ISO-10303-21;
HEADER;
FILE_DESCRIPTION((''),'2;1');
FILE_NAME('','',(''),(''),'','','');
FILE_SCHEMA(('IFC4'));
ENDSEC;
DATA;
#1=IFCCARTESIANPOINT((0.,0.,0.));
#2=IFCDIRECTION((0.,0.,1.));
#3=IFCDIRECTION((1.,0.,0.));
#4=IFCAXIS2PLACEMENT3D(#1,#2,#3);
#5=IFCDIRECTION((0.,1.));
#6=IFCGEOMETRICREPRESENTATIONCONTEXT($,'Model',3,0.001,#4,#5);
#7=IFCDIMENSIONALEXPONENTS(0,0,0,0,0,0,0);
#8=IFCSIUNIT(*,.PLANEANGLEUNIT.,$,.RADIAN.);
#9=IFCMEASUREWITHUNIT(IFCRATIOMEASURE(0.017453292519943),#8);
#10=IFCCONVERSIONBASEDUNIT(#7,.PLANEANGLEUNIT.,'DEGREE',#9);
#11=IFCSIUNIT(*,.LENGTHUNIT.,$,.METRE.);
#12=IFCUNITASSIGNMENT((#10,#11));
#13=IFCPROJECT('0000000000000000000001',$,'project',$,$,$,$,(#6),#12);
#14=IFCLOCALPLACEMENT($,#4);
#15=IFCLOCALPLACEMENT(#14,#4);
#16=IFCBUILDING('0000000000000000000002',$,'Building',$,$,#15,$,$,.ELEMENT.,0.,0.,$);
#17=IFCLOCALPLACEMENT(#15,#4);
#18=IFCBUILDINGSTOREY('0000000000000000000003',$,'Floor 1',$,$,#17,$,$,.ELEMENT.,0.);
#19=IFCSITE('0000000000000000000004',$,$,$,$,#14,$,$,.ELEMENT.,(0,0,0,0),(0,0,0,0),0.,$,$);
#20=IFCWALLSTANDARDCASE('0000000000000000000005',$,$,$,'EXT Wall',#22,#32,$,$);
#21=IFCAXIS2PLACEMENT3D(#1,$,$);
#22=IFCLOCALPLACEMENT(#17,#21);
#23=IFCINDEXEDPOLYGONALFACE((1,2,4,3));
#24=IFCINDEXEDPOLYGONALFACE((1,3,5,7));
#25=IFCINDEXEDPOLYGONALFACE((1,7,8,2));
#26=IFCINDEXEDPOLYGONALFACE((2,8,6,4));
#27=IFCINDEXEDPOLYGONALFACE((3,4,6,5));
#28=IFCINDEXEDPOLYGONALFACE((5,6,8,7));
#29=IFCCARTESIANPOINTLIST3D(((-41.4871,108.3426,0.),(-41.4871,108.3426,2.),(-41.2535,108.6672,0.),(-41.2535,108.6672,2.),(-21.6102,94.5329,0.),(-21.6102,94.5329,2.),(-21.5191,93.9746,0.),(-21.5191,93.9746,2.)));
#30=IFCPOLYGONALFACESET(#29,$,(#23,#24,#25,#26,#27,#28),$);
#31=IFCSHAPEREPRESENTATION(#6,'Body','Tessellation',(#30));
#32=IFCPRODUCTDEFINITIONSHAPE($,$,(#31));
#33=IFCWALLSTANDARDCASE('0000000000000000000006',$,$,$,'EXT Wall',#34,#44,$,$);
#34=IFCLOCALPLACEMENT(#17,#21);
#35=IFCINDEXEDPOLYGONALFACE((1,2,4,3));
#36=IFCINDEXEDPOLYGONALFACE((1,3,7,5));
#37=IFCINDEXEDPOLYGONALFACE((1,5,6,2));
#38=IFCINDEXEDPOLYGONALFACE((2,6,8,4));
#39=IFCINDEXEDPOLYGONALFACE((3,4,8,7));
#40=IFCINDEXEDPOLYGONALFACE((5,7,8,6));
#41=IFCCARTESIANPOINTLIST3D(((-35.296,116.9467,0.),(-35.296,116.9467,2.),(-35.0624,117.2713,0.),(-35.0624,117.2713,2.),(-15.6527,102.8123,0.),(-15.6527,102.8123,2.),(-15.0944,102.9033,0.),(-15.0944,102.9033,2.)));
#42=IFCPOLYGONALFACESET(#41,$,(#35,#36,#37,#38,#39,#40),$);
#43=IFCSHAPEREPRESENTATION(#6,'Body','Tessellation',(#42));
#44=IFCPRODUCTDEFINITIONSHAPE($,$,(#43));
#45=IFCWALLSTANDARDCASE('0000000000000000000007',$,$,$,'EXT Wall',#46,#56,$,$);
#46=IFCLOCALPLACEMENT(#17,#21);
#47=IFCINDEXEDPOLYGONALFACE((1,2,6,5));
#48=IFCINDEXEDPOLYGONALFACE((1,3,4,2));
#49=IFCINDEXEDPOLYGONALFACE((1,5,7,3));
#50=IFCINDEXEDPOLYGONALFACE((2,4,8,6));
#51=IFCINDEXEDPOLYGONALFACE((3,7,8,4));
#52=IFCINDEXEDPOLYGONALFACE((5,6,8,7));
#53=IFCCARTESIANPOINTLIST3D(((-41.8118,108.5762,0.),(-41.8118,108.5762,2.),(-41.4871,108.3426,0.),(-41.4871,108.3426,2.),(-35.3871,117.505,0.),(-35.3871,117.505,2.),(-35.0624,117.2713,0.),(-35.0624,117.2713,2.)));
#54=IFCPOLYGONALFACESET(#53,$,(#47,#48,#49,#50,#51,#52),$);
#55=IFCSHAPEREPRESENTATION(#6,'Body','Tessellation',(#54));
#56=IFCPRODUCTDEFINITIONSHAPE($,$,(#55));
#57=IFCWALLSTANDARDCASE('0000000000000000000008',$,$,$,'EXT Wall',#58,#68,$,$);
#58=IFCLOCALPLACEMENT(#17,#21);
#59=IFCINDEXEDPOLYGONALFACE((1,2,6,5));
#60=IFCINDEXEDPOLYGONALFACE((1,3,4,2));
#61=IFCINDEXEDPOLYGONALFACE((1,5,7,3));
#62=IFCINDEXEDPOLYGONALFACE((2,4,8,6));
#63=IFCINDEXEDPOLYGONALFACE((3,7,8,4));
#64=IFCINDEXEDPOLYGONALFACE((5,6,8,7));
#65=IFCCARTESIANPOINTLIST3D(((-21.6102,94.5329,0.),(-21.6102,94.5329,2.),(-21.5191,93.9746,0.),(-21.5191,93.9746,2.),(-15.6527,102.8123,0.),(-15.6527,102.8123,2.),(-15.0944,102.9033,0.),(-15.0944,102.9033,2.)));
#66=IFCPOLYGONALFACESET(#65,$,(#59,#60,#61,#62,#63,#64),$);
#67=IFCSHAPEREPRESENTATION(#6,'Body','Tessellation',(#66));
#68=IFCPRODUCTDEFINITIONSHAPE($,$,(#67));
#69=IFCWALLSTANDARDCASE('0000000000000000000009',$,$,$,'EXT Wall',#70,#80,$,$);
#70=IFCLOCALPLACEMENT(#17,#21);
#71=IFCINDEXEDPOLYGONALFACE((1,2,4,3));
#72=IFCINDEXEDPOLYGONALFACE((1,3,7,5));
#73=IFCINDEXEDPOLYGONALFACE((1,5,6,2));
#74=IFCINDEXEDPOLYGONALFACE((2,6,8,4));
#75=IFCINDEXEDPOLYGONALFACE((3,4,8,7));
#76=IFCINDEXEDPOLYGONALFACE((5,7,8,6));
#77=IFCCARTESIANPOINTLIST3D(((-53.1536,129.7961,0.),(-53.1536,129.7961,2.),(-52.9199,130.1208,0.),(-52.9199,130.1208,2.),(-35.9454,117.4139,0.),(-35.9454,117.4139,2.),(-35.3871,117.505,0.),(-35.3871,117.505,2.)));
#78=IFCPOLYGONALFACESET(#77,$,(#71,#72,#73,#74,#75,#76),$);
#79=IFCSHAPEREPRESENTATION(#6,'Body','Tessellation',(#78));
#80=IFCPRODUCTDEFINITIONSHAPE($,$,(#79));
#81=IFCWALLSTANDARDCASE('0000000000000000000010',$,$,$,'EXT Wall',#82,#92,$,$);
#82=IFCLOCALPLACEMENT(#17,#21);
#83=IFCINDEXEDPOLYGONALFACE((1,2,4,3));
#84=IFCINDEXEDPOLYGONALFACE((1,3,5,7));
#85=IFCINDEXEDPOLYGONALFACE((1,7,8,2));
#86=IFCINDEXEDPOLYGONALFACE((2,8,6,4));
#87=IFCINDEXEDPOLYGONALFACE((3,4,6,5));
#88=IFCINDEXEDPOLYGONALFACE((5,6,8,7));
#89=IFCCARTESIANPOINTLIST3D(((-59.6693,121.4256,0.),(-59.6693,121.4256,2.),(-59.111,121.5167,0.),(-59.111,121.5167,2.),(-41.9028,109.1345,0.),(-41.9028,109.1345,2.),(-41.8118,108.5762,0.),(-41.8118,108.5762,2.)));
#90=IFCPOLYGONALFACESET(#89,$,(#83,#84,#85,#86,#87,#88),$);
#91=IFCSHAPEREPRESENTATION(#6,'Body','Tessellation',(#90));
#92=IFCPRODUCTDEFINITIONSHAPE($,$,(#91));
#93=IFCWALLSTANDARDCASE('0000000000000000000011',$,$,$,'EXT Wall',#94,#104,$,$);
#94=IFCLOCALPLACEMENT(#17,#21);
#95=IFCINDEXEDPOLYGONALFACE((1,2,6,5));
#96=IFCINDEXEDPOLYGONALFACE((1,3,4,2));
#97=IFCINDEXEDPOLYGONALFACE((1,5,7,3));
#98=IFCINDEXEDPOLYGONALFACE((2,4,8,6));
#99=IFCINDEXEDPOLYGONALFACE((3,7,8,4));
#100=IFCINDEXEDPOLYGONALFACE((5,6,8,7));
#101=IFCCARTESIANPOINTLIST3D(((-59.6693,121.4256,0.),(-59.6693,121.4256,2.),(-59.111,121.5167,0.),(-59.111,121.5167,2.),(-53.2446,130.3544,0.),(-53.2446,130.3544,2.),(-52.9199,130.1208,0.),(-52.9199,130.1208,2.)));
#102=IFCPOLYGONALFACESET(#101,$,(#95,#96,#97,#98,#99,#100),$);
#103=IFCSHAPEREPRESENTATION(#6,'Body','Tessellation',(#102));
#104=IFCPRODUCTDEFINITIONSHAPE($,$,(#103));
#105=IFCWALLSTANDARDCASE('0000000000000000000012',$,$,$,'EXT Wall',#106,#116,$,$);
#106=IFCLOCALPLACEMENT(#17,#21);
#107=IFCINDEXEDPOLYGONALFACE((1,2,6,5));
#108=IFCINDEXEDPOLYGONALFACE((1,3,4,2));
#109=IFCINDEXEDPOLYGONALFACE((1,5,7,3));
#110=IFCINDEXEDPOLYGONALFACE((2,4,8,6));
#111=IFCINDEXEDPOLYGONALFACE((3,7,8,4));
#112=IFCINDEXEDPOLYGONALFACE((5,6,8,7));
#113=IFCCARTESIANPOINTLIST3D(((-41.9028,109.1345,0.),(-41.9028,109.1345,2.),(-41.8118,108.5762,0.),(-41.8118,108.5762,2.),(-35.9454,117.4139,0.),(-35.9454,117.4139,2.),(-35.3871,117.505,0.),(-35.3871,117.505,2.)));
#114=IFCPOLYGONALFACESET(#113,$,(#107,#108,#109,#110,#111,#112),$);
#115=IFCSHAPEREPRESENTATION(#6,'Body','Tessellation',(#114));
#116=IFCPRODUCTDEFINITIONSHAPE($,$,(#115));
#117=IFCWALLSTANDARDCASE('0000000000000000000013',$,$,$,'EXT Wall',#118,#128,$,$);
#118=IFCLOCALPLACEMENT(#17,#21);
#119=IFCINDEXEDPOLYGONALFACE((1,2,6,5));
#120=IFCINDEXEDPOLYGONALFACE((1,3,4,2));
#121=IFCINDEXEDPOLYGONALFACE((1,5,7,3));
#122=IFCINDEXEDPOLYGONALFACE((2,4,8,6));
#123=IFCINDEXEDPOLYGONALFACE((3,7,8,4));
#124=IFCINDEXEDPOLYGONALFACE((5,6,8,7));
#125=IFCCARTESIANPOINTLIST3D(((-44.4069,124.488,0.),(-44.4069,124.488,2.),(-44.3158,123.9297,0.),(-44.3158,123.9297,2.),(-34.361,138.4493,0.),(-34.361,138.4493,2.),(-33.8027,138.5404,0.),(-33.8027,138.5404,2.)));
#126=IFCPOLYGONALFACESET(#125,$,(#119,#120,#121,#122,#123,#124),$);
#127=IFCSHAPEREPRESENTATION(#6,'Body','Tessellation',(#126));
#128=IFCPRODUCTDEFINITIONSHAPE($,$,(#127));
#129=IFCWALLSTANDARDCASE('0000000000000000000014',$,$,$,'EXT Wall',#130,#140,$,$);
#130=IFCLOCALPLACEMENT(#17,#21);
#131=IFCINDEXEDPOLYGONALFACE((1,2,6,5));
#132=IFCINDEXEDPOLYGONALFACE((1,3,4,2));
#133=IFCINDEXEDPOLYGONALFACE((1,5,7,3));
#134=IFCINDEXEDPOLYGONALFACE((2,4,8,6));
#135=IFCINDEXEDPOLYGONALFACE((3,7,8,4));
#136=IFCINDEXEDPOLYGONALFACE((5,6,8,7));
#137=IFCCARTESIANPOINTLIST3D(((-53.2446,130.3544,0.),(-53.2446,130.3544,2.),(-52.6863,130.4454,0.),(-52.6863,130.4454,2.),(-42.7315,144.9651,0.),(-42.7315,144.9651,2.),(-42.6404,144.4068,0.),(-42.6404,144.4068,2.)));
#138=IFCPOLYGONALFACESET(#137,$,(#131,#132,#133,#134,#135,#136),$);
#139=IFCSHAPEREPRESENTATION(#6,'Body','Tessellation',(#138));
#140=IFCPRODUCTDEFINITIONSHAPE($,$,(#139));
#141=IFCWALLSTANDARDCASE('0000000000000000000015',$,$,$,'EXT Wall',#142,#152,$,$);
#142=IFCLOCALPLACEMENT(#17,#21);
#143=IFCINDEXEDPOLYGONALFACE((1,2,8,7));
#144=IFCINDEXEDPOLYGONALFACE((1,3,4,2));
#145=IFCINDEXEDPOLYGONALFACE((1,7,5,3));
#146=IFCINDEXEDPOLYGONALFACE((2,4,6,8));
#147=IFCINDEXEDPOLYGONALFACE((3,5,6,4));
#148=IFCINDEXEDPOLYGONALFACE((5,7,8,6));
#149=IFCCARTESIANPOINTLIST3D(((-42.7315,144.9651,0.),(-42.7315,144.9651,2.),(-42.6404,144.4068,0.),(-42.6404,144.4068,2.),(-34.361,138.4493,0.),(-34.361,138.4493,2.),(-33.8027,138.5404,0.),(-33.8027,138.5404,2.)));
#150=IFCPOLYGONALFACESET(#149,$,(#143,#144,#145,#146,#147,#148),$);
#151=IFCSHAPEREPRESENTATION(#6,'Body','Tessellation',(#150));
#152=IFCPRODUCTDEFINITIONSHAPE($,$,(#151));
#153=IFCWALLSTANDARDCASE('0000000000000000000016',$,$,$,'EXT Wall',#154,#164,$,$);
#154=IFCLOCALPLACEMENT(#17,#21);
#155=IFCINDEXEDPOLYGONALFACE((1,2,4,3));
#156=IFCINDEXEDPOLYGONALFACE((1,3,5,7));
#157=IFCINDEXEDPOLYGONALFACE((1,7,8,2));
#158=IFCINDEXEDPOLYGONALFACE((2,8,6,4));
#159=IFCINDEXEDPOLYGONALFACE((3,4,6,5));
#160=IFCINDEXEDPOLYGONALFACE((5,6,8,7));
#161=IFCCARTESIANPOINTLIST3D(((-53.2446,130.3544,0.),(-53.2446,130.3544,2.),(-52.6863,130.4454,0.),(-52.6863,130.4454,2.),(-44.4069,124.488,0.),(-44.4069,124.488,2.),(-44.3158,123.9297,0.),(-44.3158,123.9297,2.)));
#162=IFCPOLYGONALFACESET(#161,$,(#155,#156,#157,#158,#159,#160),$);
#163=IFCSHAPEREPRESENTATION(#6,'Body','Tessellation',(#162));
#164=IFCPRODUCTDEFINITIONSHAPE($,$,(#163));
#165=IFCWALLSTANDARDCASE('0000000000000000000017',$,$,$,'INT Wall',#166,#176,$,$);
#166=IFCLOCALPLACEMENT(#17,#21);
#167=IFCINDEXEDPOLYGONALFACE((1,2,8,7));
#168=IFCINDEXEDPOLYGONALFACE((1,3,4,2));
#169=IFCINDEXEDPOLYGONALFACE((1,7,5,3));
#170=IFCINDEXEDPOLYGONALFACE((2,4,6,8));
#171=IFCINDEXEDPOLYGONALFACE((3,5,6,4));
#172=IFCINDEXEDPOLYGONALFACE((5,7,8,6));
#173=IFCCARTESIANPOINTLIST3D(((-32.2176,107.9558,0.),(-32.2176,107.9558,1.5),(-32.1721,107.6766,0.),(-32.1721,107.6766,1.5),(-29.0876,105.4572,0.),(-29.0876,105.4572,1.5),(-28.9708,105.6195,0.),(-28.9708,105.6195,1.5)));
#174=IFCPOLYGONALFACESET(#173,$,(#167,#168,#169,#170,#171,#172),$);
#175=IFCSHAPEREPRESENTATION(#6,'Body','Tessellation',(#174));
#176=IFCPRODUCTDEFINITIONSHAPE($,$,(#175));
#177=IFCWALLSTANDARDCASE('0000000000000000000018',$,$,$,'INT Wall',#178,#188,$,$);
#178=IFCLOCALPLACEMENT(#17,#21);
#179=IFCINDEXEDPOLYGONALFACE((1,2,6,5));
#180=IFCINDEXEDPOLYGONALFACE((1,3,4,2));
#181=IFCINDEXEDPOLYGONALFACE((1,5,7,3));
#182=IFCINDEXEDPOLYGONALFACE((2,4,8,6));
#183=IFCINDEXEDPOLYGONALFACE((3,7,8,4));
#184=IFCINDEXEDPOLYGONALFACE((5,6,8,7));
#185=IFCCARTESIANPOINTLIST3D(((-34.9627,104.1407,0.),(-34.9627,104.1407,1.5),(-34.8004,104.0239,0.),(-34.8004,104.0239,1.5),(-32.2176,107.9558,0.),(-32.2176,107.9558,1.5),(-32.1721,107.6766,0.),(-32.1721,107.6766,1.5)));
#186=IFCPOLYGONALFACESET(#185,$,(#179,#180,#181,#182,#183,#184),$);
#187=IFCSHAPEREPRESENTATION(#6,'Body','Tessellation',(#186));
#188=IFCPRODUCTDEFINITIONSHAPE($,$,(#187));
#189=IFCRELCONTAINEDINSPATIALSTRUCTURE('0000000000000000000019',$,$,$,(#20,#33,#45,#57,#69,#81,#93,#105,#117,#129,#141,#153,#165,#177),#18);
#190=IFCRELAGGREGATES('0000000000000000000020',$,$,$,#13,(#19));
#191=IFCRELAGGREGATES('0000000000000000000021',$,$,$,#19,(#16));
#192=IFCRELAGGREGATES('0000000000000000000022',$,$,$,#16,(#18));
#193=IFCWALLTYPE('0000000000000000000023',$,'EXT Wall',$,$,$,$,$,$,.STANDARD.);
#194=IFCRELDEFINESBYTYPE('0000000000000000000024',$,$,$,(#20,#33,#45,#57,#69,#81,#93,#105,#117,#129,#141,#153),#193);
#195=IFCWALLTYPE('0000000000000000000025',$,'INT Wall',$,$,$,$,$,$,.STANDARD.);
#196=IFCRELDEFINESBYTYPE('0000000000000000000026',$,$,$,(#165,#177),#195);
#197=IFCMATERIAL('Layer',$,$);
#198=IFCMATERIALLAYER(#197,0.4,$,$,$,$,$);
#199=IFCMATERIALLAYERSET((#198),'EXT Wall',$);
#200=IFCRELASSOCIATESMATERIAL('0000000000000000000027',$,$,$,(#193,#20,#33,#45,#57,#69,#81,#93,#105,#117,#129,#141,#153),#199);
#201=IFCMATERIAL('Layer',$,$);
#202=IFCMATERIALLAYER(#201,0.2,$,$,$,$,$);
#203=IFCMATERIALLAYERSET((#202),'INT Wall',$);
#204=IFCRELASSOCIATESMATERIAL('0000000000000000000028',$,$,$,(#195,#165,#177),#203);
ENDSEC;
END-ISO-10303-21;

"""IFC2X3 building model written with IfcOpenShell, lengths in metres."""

from ifc_helpers import new_model, entity, si_unit, converted_unit, direction, frame, origin_with_axes, place, context, project, spatial, polyline, outline, extrude, material, layer, layer_set, layer_usage, type_object, element, save


model = new_model("IFC2X3")

# Units and contexts
model_context = context("Model", 3, precision=0.001, world=origin_with_axes(), true_north=direction((0.0, 1.0)))
ifc_project = project(units=[converted_unit("PLANEANGLEUNIT", "DEGREE", entity("IfcRatioMeasure", 0.017453292519943), si_unit("PLANEANGLEUNIT", "RADIAN"), dimensions=[0, 0, 0, 0, 0, 0, 0]), si_unit("LENGTHUNIT", "METRE")], contexts=[model_context])

# Site, building, storey
site_placement = place(None, origin_with_axes())
site = spatial("IfcSite", under=ifc_project, at=site_placement, CompositionType="ELEMENT", RefLatitude=(0, 0, 0, 0), RefLongitude=(0, 0, 0, 0), RefElevation=0.0)
building_placement = place(site_placement, origin_with_axes())
building = spatial("IfcBuilding", under=site, at=building_placement, Name="Building", CompositionType="ELEMENT", ElevationOfRefHeight=0.0, ElevationOfTerrain=0.0)
storey_placement = place(building_placement, origin_with_axes())
storey = spatial("IfcBuildingStorey", under=building, at=storey_placement, Name="Floor 1", CompositionType="ELEMENT", Elevation=0.0)

# Walls
ifc_material_1 = material(Name="Layer")
ifc_layer_1 = layer(ifc_material_1, 0.4)
ifc_layer_set_1 = layer_set([ifc_layer_1], Name="EXT Wall")
ifc_layer_usage_1 = layer_usage(ifc_layer_set_1, "AXIS2", "POSITIVE", -0.2)
wall_type_1 = type_object("IfcWallType", Name="EXT Wall", PredefinedType="STANDARD", material=ifc_layer_set_1)
wall_1_placement = place(site_placement, frame((-41.8118, 108.5762, 0.0), z_axis=(0.0, 0.0, 1.0), x_axis=(0.811707, -0.584065, 0.0)))
element("IfcWallStandardCase", 1, at=wall_1_placement, inside=storey, type_object=wall_type_1, material=ifc_layer_usage_1, ObjectType="EXT Wall", context=model_context, shape_type="SweptSolid", body=[
    extrude(outline(polyline([(0.4, 0.0), (0.4, 0.4), (24.6, 0.4), (25.0, 0.0), (0.4, 0.0)])), origin_with_axes(), (0.0, 0.0, 1.0), 2.0),
])
wall_2_placement = place(site_placement, frame((-15.0944, 102.9033, 0.0), z_axis=(0.0, 0.0, 1.0), x_axis=(-0.811707, 0.584065, 0.0)))
element("IfcWallStandardCase", 2, at=wall_2_placement, inside=storey, type_object=wall_type_1, material=ifc_layer_usage_1, ObjectType="EXT Wall", context=model_context, shape_type="SweptSolid", body=[
    extrude(outline(polyline([(24.6, 0.4), (24.6, 0.0), (0.0, 0.0), (0.4, 0.4), (24.6, 0.4)])), origin_with_axes(), (0.0, 0.0, 1.0), 2.0),
])
wall_3_placement = place(site_placement, frame((-35.3871, 117.505, 0.0), z_axis=(0.0, 0.0, 1.0), x_axis=(-0.584065, -0.811707, 0.0)))
element("IfcWallStandardCase", 3, at=wall_3_placement, inside=storey, type_object=wall_type_1, material=ifc_layer_usage_1, ObjectType="EXT Wall", context=model_context, shape_type="SweptSolid", body=[
    extrude(outline(polyline([(11.0, 0.0), (11.0, 0.4), (0.0, 0.4), (0.0, 0.0), (11.0, 0.0)])), origin_with_axes(), (0.0, 0.0, 1.0), 2.0),
])
wall_4_placement = place(site_placement, frame((-21.5191, 93.9746, 0.0), z_axis=(0.0, 0.0, 1.0), x_axis=(0.584065, 0.811707, 0.0)))
element("IfcWallStandardCase", 4, at=wall_4_placement, inside=storey, type_object=wall_type_1, material=ifc_layer_usage_1, ObjectType="EXT Wall", context=model_context, shape_type="SweptSolid", body=[
    extrude(outline(polyline([(11.0, 0.0), (10.6, 0.4), (0.4, 0.4), (0.0, 0.0), (11.0, 0.0)])), origin_with_axes(), (0.0, 0.0, 1.0), 2.0),
])
wall_5_placement = place(site_placement, frame((-53.2446, 130.3544, 0.0), z_axis=(0.0, 0.0, 1.0), x_axis=(0.811707, -0.584065, 0.0)))
element("IfcWallStandardCase", 5, at=wall_5_placement, inside=storey, type_object=wall_type_1, material=ifc_layer_usage_1, ObjectType="EXT Wall", context=model_context, shape_type="SweptSolid", body=[
    extrude(outline(polyline([(0.4, 0.0), (0.4, -0.4), (21.6, -0.4), (22.0, 0.0), (0.4, 0.0)])), origin_with_axes(), (0.0, 0.0, 1.0), 2.0),
])
wall_6_placement = place(site_placement, frame((-41.8118, 108.5762, 0.0), z_axis=(0.0, 0.0, 1.0), x_axis=(-0.811707, 0.584065, 0.0)))
element("IfcWallStandardCase", 6, at=wall_6_placement, inside=storey, type_object=wall_type_1, material=ifc_layer_usage_1, ObjectType="EXT Wall", context=model_context, shape_type="SweptSolid", body=[
    extrude(outline(polyline([(21.6, -0.4), (22.0, 0.0), (0.0, 0.0), (0.4, -0.4), (21.6, -0.4)])), origin_with_axes(), (0.0, 0.0, 1.0), 2.0),
])
wall_7_placement = place(site_placement, frame((-59.6693, 121.4256, 0.0), z_axis=(0.0, 0.0, 1.0), x_axis=(0.584065, 0.811707, 0.0)))
element("IfcWallStandardCase", 7, at=wall_7_placement, inside=storey, type_object=wall_type_1, material=ifc_layer_usage_1, ObjectType="EXT Wall", context=model_context, shape_type="SweptSolid", body=[
    extrude(outline(polyline([(11.0, 0.0), (11.0, -0.4), (0.4, -0.4), (0.0, 0.0), (11.0, 0.0)])), origin_with_axes(), (0.0, 0.0, 1.0), 2.0),
])
wall_8_placement = place(site_placement, frame((-35.3871, 117.505, 0.0), z_axis=(0.0, 0.0, 1.0), x_axis=(-0.584065, -0.811707, 0.0)))
element("IfcWallStandardCase", 8, at=wall_8_placement, inside=storey, type_object=wall_type_1, material=ifc_layer_usage_1, ObjectType="EXT Wall", context=model_context, shape_type="SweptSolid", body=[
    extrude(outline(polyline([(10.6, -0.4), (11.0, 0.0), (0.0, 0.0), (0.4, -0.4), (10.6, -0.4)])), origin_with_axes(), (0.0, 0.0, 1.0), 2.0),
])
wall_9_placement = place(site_placement, frame((-44.3158, 123.9297, 0.0), z_axis=(0.0, 0.0, 1.0), x_axis=(0.584065, 0.811707, 0.0)))
element("IfcWallStandardCase", 9, at=wall_9_placement, inside=storey, type_object=wall_type_1, material=ifc_layer_usage_1, ObjectType="EXT Wall", context=model_context, shape_type="SweptSolid", body=[
    extrude(outline(polyline([(0.0, 0.0), (0.4, 0.4), (17.6, 0.4), (18.0, 0.0), (0.0, 0.0)])), origin_with_axes(), (0.0, 0.0, 1.0), 2.0),
])
wall_10_placement = place(site_placement, frame((-42.7315, 144.9651, 0.0), z_axis=(0.0, 0.0, 1.0), x_axis=(-0.584065, -0.811707, 0.0)))
element("IfcWallStandardCase", 10, at=wall_10_placement, inside=storey, type_object=wall_type_1, material=ifc_layer_usage_1, ObjectType="EXT Wall", context=model_context, shape_type="SweptSolid", body=[
    extrude(outline(polyline([(18.0, 0.0), (17.6, 0.4), (0.4, 0.4), (0.0, 0.0), (18.0, 0.0)])), origin_with_axes(), (0.0, 0.0, 1.0), 2.0),
])
wall_11_placement = place(site_placement, frame((-33.8027, 138.5404, 0.0), z_axis=(0.0, 0.0, 1.0), x_axis=(-0.811707, 0.584065, 0.0)))
element("IfcWallStandardCase", 11, at=wall_11_placement, inside=storey, type_object=wall_type_1, material=ifc_layer_usage_1, ObjectType="EXT Wall", context=model_context, shape_type="SweptSolid", body=[
    extrude(outline(polyline([(11.0, 0.0), (10.6, 0.4), (0.4, 0.4), (0.0, 0.0), (11.0, 0.0)])), origin_with_axes(), (0.0, 0.0, 1.0), 2.0),
])
wall_12_placement = place(site_placement, frame((-53.2446, 130.3544, 0.0), z_axis=(0.0, 0.0, 1.0), x_axis=(0.811707, -0.584065, 0.0)))
element("IfcWallStandardCase", 12, at=wall_12_placement, inside=storey, type_object=wall_type_1, material=ifc_layer_usage_1, ObjectType="EXT Wall", context=model_context, shape_type="SweptSolid", body=[
    extrude(outline(polyline([(11.0, 0.0), (10.6, 0.4), (0.4, 0.4), (0.0, 0.0), (11.0, 0.0)])), origin_with_axes(), (0.0, 0.0, 1.0), 2.0),
])
ifc_material_2 = material(Name="Layer")
ifc_layer_2 = layer(ifc_material_2, 0.2)
ifc_layer_set_2 = layer_set([ifc_layer_2], Name="INT Wall")
ifc_layer_usage_2 = layer_usage(ifc_layer_set_2, "AXIS2", "POSITIVE", -0.1)
wall_type_2 = type_object("IfcWallType", Name="INT Wall", PredefinedType="STANDARD", material=ifc_layer_set_2)
wall_13_placement = place(site_placement, frame((-28.948, 105.4799, 0.0), z_axis=(0.0, 0.0, 1.0), x_axis=(-0.811707, 0.584065, 0.0)))
element("IfcWallStandardCase", 13, at=wall_13_placement, inside=storey, type_object=wall_type_2, material=ifc_layer_usage_2, ObjectType="INT Wall", context=model_context, shape_type="SweptSolid", body=[
    extrude(outline(polyline([(0.1, 0.1), (0.1, -0.1), (4.1, -0.1), (3.9, 0.1), (0.1, 0.1)])), origin_with_axes(), (0.0, 0.0, 1.0), 1.5),
])
wall_14_placement = place(site_placement, frame((-32.1949, 107.8162, 0.0), z_axis=(0.0, 0.0, 1.0), x_axis=(-0.584065, -0.811707, 0.0)))
element("IfcWallStandardCase", 14, at=wall_14_placement, inside=storey, type_object=wall_type_2, material=ifc_layer_usage_2, ObjectType="INT Wall", context=model_context, shape_type="SweptSolid", body=[
    extrude(outline(polyline([(4.6, 0.1), (4.6, -0.1), (-0.1, -0.1), (0.1, 0.1), (4.6, 0.1)])), origin_with_axes(), (0.0, 0.0, 1.0), 1.5),
])

save(model, "model.ifc")
